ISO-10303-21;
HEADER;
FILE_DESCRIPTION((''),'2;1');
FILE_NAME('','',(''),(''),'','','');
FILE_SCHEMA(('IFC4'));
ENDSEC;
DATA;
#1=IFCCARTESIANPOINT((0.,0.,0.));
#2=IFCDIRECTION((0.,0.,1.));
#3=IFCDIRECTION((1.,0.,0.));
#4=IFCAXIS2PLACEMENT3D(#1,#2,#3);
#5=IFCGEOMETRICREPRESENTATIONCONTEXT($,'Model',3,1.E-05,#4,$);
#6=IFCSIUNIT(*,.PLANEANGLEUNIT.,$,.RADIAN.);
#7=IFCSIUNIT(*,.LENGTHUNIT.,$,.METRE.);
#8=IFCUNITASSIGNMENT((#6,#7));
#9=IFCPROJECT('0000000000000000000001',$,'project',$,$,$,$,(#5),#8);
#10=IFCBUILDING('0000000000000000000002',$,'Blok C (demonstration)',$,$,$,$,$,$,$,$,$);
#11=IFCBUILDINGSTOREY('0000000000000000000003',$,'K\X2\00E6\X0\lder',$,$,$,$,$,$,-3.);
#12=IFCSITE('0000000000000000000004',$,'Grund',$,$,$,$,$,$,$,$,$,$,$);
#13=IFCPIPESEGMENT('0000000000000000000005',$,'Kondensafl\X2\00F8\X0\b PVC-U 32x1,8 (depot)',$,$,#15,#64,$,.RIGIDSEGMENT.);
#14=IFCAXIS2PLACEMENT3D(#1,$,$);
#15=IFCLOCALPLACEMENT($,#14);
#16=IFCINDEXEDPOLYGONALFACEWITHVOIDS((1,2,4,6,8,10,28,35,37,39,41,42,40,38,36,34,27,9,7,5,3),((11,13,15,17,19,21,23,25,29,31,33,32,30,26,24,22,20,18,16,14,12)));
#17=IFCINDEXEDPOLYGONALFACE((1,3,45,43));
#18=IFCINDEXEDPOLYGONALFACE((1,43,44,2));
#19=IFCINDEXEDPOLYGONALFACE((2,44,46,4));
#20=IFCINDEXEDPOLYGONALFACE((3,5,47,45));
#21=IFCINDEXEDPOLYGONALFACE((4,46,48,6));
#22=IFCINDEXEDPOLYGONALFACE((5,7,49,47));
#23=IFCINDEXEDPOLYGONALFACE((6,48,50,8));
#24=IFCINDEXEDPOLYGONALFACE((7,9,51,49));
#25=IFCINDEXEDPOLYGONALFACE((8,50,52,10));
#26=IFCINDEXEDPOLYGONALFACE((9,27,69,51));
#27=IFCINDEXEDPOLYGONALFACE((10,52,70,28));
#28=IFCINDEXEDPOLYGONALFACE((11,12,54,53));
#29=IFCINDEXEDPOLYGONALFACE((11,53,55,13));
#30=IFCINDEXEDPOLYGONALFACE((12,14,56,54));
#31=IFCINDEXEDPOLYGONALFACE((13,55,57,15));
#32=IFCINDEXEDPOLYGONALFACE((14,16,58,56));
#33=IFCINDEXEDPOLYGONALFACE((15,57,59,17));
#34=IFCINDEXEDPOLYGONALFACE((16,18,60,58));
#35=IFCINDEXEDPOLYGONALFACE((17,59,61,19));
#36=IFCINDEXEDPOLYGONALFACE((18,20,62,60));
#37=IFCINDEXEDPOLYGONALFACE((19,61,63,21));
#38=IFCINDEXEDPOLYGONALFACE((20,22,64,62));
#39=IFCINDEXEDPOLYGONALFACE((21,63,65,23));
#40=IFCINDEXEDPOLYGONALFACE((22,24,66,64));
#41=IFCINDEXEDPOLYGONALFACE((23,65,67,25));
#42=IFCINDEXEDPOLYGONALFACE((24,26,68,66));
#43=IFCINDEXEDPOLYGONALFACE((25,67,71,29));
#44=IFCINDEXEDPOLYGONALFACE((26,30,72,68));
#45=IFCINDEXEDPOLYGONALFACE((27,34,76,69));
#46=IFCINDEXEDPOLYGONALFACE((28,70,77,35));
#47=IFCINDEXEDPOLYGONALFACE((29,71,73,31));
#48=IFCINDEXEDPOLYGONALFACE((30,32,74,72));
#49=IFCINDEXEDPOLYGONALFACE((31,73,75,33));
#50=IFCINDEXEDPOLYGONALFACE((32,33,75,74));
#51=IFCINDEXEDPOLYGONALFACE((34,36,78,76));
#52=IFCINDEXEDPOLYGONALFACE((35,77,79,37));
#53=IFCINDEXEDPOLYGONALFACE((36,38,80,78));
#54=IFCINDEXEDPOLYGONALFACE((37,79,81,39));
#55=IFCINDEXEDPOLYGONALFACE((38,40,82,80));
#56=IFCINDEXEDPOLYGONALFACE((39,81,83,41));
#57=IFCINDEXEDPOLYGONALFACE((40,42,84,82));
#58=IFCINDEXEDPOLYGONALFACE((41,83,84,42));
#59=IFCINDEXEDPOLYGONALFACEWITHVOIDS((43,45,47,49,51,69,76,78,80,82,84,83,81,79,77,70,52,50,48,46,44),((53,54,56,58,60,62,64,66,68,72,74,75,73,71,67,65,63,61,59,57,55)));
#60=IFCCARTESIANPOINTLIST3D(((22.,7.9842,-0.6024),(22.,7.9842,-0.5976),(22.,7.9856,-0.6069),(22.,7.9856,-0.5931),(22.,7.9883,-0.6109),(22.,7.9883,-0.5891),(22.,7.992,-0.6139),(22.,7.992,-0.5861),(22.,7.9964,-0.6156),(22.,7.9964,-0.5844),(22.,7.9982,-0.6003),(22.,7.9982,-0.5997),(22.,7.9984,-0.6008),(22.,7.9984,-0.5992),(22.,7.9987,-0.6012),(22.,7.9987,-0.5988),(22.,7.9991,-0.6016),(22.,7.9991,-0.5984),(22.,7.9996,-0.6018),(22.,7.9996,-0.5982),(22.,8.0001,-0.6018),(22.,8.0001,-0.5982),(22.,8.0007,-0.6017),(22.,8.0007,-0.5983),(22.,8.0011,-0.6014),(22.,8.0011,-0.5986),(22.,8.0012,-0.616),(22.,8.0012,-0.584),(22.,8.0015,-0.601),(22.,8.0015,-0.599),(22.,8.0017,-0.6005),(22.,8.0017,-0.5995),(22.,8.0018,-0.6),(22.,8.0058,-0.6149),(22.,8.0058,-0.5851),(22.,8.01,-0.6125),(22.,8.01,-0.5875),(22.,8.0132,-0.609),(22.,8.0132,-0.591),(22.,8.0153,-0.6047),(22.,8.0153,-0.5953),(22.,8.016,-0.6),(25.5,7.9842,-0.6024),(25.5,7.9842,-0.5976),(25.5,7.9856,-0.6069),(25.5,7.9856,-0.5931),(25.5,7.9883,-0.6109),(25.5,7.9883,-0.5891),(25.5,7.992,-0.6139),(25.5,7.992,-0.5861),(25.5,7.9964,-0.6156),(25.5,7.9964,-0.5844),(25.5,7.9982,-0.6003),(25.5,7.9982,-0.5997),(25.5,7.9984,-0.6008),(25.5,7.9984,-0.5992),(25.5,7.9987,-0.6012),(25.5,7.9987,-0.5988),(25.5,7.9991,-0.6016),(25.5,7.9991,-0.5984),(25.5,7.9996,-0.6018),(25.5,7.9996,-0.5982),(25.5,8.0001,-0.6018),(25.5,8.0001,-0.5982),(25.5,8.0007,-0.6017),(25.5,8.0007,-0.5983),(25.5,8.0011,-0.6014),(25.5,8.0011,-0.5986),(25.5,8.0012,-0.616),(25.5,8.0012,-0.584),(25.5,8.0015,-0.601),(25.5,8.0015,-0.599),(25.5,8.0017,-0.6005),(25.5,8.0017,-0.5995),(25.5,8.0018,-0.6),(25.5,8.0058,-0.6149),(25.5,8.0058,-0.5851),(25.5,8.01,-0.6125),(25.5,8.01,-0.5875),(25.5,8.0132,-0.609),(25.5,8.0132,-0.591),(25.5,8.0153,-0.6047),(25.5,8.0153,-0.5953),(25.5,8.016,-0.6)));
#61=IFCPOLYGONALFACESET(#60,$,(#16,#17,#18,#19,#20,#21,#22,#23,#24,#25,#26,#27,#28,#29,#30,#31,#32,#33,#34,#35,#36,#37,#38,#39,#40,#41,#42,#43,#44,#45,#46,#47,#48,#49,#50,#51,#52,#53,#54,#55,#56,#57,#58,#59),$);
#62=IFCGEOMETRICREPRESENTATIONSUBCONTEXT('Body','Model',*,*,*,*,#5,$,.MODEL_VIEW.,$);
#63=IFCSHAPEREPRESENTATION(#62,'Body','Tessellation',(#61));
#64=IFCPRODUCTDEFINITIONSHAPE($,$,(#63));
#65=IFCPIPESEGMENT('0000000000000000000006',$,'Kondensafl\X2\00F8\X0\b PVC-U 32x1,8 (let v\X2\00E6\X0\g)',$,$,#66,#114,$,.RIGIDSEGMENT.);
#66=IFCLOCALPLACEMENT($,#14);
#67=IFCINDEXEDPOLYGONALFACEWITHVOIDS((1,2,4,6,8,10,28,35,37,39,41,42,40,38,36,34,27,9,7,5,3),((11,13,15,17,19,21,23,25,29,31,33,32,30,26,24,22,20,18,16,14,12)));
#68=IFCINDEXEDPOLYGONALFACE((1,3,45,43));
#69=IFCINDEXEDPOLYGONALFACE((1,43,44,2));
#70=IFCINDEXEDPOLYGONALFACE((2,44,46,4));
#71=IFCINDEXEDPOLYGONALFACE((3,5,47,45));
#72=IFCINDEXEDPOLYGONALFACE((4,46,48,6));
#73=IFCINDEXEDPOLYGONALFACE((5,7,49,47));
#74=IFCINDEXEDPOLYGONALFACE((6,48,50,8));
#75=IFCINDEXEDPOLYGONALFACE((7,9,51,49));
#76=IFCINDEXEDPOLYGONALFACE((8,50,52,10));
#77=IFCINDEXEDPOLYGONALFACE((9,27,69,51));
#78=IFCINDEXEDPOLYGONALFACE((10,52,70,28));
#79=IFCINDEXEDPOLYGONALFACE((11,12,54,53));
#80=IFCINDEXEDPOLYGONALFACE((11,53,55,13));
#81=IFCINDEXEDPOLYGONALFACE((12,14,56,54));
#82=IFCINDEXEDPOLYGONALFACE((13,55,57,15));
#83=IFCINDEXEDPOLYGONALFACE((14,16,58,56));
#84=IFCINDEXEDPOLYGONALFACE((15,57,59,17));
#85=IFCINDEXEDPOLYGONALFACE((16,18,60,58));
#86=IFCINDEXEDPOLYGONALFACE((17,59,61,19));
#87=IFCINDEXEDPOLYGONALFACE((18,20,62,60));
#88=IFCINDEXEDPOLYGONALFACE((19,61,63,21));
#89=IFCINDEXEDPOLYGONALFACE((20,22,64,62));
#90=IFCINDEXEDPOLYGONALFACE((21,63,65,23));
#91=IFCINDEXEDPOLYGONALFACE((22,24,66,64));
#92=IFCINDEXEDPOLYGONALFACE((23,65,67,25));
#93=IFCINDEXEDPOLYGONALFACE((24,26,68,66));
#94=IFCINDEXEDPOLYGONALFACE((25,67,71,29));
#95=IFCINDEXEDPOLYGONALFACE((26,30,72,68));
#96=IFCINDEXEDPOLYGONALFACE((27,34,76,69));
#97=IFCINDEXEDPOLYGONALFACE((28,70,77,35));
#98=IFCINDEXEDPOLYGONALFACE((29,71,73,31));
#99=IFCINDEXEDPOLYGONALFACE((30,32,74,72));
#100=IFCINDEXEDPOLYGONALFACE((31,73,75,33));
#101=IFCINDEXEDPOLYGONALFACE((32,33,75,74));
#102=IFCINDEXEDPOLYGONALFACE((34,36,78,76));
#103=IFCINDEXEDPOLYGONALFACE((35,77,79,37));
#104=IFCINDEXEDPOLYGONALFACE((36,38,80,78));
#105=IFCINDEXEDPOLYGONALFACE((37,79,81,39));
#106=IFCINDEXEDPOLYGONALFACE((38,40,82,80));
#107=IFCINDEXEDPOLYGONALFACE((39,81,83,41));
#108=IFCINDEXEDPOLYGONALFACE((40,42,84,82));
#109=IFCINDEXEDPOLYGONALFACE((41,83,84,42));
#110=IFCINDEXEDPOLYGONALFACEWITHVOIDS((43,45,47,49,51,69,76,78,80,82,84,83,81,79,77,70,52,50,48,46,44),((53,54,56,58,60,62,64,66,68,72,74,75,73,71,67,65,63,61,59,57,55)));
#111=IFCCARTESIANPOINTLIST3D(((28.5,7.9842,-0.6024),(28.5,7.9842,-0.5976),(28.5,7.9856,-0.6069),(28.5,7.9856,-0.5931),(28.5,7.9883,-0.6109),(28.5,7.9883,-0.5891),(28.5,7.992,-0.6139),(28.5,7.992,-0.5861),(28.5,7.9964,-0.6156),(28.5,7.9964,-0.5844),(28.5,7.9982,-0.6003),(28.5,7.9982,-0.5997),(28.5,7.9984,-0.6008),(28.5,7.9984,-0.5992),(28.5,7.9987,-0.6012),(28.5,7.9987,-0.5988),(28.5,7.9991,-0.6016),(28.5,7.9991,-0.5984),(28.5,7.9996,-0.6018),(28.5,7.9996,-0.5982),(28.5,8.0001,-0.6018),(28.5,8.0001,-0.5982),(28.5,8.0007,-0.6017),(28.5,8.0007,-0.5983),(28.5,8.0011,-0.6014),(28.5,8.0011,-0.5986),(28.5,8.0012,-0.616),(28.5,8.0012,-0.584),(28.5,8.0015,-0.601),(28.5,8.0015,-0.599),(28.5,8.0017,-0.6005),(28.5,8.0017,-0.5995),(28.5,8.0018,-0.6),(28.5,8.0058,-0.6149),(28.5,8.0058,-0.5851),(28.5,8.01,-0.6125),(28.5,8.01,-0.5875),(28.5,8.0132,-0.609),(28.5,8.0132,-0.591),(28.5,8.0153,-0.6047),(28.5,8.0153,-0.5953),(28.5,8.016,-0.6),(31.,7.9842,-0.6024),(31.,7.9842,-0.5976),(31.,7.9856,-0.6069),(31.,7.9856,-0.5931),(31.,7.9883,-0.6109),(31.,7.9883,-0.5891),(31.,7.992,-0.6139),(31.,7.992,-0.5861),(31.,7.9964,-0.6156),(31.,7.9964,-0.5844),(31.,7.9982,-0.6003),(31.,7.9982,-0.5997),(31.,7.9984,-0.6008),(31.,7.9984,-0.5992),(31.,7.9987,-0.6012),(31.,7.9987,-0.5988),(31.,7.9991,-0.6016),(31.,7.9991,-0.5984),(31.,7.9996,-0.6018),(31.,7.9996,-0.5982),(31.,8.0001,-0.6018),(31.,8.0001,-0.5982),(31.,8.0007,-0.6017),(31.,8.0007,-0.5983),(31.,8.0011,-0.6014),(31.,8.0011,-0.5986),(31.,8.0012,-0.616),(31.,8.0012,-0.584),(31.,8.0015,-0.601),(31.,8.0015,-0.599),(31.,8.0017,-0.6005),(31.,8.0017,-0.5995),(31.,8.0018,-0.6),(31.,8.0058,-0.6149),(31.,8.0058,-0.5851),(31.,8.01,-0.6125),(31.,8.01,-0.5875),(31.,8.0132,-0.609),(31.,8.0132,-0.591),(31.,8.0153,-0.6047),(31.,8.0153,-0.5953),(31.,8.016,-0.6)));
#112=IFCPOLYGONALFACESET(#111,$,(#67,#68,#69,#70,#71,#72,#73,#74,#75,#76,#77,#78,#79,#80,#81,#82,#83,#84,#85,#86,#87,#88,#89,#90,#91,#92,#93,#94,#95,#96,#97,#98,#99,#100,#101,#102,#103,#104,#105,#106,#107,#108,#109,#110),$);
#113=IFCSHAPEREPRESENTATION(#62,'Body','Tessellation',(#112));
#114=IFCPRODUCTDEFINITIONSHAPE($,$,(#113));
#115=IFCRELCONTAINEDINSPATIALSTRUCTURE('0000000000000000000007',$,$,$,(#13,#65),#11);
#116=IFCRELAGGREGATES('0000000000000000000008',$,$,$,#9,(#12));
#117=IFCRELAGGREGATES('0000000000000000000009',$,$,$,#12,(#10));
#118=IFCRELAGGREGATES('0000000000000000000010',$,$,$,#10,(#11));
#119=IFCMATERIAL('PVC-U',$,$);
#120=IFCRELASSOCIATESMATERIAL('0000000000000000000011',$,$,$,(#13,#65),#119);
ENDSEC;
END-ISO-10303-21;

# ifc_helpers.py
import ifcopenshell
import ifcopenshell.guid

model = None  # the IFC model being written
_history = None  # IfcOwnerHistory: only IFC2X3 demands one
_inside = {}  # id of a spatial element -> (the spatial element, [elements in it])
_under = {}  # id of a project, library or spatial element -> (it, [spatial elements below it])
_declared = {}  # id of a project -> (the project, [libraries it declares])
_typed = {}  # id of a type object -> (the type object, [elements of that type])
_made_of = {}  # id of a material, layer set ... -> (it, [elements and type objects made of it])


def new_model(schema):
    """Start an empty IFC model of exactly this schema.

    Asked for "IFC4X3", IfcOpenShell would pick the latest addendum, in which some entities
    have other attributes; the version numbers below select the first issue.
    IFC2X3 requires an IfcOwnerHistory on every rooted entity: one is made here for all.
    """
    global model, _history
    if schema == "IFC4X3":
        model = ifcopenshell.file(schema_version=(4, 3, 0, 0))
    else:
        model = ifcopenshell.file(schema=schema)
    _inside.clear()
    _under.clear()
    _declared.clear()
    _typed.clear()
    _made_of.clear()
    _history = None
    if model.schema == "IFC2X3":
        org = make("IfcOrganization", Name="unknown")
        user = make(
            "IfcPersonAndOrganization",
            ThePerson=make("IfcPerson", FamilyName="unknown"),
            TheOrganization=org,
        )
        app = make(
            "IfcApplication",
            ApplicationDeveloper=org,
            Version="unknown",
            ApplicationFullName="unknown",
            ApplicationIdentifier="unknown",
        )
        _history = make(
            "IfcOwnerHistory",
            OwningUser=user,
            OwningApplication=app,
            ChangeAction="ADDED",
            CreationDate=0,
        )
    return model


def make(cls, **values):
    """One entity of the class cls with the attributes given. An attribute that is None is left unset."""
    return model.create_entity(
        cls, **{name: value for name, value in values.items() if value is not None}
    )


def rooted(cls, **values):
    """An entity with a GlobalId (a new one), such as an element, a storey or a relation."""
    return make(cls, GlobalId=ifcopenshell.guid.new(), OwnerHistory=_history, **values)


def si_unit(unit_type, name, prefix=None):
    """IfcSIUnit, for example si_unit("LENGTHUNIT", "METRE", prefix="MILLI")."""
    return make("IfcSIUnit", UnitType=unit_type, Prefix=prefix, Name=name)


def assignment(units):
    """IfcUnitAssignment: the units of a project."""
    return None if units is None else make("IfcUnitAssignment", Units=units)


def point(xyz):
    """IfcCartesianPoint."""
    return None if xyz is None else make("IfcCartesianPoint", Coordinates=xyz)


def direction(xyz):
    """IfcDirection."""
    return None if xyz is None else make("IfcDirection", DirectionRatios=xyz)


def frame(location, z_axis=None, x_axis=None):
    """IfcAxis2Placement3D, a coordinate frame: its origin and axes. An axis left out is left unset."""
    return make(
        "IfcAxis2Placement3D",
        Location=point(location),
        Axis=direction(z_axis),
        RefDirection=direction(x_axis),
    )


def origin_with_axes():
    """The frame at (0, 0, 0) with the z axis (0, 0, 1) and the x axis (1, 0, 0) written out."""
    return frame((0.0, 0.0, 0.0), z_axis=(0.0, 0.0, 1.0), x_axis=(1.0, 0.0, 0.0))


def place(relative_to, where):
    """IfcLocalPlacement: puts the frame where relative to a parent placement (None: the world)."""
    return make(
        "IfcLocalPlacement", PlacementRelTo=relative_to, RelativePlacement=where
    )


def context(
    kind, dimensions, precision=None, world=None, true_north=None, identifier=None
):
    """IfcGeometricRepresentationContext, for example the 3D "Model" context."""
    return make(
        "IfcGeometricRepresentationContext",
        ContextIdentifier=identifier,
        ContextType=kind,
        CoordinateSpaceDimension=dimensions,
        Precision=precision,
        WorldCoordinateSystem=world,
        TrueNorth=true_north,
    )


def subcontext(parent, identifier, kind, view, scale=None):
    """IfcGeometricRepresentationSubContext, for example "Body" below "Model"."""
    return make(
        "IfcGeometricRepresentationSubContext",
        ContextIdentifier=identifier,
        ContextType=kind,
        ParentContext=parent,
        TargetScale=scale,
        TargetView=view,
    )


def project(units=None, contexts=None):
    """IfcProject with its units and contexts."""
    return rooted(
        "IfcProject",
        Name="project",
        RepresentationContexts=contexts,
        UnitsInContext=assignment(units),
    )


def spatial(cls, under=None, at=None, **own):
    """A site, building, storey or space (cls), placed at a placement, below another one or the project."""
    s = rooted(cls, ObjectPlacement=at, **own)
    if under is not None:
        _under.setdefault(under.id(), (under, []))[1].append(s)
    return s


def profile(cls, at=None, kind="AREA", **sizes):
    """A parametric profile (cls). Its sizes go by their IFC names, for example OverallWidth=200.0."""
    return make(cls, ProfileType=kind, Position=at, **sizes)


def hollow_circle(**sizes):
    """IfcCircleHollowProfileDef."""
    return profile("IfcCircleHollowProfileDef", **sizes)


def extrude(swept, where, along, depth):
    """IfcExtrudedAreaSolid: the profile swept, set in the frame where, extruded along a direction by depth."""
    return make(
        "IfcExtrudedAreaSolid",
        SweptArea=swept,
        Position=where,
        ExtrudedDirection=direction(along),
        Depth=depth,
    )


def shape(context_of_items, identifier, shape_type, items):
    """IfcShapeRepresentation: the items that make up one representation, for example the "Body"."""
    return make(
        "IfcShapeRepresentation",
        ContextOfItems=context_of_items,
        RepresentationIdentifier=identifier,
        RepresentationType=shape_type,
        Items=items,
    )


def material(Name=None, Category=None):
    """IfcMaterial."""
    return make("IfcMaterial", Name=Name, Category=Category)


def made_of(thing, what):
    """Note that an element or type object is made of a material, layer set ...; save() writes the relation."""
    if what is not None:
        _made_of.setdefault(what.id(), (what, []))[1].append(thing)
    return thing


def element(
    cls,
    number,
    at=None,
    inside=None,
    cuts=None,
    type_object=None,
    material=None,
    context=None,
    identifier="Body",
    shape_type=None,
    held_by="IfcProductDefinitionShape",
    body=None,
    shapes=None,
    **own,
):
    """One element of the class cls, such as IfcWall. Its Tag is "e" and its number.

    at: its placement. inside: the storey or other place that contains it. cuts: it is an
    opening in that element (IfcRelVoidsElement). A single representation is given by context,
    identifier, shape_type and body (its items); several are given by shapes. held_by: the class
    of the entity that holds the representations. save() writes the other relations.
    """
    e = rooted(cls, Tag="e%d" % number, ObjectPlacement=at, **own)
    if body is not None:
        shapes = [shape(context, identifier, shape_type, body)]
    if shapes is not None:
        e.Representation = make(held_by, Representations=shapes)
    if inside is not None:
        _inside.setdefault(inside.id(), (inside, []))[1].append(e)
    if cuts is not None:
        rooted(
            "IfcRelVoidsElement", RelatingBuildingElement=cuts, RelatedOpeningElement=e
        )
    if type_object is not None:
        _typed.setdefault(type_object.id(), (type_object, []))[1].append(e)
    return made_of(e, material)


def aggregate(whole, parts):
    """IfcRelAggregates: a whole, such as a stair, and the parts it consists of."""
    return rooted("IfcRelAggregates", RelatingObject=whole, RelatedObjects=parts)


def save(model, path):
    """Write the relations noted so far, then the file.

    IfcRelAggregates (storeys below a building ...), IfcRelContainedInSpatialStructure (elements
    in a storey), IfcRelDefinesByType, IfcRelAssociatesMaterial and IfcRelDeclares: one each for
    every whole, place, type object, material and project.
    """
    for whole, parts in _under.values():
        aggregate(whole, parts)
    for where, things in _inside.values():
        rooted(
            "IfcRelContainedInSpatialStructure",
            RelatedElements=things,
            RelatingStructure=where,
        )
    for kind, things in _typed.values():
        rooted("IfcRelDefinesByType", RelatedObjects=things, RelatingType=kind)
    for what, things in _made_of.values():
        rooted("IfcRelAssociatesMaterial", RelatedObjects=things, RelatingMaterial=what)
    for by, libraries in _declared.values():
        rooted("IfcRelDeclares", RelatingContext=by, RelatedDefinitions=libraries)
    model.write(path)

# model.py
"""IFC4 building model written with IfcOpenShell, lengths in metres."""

from ifc_helpers import new_model, si_unit, frame, origin_with_axes, place, context, subcontext, project, spatial, hollow_circle, extrude, material, element, save


model = new_model("IFC4")

# Units and contexts
model_context = context("Model", 3, precision=1e-05, world=origin_with_axes())
body_context = subcontext(model_context, "Body", "Model", "MODEL_VIEW")
ifc_project = project(units=[si_unit("PLANEANGLEUNIT", "RADIAN"), si_unit("LENGTHUNIT", "METRE")], contexts=[model_context])

# Site, building, storey
site = spatial("IfcSite", under=ifc_project, Name="Grund")
building = spatial("IfcBuilding", under=site, Name="Blok C (demonstration)")
storey = spatial("IfcBuildingStorey", under=building, Name="Kælder", Elevation=-3.0)

# Pipe segments
ifc_material_1 = material(Name="PVC-U")
pipe_segment_1_placement = place(None, origin_with_axes())
element("IfcPipeSegment", 1, at=pipe_segment_1_placement, inside=storey, material=ifc_material_1, Name="Kondensafløb PVC-U 32x1,8 (depot)", PredefinedType="RIGIDSEGMENT", context=body_context, shape_type="SweptSolid", body=[
    extrude(hollow_circle(Radius=0.016, WallThickness=0.0142), frame((22.0, 8.0, -0.6), z_axis=(1.0, 0.0, 0.0), x_axis=(0.0, 1.0, 0.0)), (0.0, 0.0, 1.0), 3.5),
])
pipe_segment_2_placement = place(None, origin_with_axes())
element("IfcPipeSegment", 2, at=pipe_segment_2_placement, inside=storey, material=ifc_material_1, Name="Kondensafløb PVC-U 32x1,8 (let væg)", PredefinedType="RIGIDSEGMENT", context=body_context, shape_type="SweptSolid", body=[
    extrude(hollow_circle(Radius=0.016, WallThickness=0.0142), frame((28.5, 8.0, -0.6), z_axis=(1.0, 0.0, 0.0), x_axis=(0.0, 1.0, 0.0)), (0.0, 0.0, 1.0), 2.5),
])

save(model, "model.ifc")
